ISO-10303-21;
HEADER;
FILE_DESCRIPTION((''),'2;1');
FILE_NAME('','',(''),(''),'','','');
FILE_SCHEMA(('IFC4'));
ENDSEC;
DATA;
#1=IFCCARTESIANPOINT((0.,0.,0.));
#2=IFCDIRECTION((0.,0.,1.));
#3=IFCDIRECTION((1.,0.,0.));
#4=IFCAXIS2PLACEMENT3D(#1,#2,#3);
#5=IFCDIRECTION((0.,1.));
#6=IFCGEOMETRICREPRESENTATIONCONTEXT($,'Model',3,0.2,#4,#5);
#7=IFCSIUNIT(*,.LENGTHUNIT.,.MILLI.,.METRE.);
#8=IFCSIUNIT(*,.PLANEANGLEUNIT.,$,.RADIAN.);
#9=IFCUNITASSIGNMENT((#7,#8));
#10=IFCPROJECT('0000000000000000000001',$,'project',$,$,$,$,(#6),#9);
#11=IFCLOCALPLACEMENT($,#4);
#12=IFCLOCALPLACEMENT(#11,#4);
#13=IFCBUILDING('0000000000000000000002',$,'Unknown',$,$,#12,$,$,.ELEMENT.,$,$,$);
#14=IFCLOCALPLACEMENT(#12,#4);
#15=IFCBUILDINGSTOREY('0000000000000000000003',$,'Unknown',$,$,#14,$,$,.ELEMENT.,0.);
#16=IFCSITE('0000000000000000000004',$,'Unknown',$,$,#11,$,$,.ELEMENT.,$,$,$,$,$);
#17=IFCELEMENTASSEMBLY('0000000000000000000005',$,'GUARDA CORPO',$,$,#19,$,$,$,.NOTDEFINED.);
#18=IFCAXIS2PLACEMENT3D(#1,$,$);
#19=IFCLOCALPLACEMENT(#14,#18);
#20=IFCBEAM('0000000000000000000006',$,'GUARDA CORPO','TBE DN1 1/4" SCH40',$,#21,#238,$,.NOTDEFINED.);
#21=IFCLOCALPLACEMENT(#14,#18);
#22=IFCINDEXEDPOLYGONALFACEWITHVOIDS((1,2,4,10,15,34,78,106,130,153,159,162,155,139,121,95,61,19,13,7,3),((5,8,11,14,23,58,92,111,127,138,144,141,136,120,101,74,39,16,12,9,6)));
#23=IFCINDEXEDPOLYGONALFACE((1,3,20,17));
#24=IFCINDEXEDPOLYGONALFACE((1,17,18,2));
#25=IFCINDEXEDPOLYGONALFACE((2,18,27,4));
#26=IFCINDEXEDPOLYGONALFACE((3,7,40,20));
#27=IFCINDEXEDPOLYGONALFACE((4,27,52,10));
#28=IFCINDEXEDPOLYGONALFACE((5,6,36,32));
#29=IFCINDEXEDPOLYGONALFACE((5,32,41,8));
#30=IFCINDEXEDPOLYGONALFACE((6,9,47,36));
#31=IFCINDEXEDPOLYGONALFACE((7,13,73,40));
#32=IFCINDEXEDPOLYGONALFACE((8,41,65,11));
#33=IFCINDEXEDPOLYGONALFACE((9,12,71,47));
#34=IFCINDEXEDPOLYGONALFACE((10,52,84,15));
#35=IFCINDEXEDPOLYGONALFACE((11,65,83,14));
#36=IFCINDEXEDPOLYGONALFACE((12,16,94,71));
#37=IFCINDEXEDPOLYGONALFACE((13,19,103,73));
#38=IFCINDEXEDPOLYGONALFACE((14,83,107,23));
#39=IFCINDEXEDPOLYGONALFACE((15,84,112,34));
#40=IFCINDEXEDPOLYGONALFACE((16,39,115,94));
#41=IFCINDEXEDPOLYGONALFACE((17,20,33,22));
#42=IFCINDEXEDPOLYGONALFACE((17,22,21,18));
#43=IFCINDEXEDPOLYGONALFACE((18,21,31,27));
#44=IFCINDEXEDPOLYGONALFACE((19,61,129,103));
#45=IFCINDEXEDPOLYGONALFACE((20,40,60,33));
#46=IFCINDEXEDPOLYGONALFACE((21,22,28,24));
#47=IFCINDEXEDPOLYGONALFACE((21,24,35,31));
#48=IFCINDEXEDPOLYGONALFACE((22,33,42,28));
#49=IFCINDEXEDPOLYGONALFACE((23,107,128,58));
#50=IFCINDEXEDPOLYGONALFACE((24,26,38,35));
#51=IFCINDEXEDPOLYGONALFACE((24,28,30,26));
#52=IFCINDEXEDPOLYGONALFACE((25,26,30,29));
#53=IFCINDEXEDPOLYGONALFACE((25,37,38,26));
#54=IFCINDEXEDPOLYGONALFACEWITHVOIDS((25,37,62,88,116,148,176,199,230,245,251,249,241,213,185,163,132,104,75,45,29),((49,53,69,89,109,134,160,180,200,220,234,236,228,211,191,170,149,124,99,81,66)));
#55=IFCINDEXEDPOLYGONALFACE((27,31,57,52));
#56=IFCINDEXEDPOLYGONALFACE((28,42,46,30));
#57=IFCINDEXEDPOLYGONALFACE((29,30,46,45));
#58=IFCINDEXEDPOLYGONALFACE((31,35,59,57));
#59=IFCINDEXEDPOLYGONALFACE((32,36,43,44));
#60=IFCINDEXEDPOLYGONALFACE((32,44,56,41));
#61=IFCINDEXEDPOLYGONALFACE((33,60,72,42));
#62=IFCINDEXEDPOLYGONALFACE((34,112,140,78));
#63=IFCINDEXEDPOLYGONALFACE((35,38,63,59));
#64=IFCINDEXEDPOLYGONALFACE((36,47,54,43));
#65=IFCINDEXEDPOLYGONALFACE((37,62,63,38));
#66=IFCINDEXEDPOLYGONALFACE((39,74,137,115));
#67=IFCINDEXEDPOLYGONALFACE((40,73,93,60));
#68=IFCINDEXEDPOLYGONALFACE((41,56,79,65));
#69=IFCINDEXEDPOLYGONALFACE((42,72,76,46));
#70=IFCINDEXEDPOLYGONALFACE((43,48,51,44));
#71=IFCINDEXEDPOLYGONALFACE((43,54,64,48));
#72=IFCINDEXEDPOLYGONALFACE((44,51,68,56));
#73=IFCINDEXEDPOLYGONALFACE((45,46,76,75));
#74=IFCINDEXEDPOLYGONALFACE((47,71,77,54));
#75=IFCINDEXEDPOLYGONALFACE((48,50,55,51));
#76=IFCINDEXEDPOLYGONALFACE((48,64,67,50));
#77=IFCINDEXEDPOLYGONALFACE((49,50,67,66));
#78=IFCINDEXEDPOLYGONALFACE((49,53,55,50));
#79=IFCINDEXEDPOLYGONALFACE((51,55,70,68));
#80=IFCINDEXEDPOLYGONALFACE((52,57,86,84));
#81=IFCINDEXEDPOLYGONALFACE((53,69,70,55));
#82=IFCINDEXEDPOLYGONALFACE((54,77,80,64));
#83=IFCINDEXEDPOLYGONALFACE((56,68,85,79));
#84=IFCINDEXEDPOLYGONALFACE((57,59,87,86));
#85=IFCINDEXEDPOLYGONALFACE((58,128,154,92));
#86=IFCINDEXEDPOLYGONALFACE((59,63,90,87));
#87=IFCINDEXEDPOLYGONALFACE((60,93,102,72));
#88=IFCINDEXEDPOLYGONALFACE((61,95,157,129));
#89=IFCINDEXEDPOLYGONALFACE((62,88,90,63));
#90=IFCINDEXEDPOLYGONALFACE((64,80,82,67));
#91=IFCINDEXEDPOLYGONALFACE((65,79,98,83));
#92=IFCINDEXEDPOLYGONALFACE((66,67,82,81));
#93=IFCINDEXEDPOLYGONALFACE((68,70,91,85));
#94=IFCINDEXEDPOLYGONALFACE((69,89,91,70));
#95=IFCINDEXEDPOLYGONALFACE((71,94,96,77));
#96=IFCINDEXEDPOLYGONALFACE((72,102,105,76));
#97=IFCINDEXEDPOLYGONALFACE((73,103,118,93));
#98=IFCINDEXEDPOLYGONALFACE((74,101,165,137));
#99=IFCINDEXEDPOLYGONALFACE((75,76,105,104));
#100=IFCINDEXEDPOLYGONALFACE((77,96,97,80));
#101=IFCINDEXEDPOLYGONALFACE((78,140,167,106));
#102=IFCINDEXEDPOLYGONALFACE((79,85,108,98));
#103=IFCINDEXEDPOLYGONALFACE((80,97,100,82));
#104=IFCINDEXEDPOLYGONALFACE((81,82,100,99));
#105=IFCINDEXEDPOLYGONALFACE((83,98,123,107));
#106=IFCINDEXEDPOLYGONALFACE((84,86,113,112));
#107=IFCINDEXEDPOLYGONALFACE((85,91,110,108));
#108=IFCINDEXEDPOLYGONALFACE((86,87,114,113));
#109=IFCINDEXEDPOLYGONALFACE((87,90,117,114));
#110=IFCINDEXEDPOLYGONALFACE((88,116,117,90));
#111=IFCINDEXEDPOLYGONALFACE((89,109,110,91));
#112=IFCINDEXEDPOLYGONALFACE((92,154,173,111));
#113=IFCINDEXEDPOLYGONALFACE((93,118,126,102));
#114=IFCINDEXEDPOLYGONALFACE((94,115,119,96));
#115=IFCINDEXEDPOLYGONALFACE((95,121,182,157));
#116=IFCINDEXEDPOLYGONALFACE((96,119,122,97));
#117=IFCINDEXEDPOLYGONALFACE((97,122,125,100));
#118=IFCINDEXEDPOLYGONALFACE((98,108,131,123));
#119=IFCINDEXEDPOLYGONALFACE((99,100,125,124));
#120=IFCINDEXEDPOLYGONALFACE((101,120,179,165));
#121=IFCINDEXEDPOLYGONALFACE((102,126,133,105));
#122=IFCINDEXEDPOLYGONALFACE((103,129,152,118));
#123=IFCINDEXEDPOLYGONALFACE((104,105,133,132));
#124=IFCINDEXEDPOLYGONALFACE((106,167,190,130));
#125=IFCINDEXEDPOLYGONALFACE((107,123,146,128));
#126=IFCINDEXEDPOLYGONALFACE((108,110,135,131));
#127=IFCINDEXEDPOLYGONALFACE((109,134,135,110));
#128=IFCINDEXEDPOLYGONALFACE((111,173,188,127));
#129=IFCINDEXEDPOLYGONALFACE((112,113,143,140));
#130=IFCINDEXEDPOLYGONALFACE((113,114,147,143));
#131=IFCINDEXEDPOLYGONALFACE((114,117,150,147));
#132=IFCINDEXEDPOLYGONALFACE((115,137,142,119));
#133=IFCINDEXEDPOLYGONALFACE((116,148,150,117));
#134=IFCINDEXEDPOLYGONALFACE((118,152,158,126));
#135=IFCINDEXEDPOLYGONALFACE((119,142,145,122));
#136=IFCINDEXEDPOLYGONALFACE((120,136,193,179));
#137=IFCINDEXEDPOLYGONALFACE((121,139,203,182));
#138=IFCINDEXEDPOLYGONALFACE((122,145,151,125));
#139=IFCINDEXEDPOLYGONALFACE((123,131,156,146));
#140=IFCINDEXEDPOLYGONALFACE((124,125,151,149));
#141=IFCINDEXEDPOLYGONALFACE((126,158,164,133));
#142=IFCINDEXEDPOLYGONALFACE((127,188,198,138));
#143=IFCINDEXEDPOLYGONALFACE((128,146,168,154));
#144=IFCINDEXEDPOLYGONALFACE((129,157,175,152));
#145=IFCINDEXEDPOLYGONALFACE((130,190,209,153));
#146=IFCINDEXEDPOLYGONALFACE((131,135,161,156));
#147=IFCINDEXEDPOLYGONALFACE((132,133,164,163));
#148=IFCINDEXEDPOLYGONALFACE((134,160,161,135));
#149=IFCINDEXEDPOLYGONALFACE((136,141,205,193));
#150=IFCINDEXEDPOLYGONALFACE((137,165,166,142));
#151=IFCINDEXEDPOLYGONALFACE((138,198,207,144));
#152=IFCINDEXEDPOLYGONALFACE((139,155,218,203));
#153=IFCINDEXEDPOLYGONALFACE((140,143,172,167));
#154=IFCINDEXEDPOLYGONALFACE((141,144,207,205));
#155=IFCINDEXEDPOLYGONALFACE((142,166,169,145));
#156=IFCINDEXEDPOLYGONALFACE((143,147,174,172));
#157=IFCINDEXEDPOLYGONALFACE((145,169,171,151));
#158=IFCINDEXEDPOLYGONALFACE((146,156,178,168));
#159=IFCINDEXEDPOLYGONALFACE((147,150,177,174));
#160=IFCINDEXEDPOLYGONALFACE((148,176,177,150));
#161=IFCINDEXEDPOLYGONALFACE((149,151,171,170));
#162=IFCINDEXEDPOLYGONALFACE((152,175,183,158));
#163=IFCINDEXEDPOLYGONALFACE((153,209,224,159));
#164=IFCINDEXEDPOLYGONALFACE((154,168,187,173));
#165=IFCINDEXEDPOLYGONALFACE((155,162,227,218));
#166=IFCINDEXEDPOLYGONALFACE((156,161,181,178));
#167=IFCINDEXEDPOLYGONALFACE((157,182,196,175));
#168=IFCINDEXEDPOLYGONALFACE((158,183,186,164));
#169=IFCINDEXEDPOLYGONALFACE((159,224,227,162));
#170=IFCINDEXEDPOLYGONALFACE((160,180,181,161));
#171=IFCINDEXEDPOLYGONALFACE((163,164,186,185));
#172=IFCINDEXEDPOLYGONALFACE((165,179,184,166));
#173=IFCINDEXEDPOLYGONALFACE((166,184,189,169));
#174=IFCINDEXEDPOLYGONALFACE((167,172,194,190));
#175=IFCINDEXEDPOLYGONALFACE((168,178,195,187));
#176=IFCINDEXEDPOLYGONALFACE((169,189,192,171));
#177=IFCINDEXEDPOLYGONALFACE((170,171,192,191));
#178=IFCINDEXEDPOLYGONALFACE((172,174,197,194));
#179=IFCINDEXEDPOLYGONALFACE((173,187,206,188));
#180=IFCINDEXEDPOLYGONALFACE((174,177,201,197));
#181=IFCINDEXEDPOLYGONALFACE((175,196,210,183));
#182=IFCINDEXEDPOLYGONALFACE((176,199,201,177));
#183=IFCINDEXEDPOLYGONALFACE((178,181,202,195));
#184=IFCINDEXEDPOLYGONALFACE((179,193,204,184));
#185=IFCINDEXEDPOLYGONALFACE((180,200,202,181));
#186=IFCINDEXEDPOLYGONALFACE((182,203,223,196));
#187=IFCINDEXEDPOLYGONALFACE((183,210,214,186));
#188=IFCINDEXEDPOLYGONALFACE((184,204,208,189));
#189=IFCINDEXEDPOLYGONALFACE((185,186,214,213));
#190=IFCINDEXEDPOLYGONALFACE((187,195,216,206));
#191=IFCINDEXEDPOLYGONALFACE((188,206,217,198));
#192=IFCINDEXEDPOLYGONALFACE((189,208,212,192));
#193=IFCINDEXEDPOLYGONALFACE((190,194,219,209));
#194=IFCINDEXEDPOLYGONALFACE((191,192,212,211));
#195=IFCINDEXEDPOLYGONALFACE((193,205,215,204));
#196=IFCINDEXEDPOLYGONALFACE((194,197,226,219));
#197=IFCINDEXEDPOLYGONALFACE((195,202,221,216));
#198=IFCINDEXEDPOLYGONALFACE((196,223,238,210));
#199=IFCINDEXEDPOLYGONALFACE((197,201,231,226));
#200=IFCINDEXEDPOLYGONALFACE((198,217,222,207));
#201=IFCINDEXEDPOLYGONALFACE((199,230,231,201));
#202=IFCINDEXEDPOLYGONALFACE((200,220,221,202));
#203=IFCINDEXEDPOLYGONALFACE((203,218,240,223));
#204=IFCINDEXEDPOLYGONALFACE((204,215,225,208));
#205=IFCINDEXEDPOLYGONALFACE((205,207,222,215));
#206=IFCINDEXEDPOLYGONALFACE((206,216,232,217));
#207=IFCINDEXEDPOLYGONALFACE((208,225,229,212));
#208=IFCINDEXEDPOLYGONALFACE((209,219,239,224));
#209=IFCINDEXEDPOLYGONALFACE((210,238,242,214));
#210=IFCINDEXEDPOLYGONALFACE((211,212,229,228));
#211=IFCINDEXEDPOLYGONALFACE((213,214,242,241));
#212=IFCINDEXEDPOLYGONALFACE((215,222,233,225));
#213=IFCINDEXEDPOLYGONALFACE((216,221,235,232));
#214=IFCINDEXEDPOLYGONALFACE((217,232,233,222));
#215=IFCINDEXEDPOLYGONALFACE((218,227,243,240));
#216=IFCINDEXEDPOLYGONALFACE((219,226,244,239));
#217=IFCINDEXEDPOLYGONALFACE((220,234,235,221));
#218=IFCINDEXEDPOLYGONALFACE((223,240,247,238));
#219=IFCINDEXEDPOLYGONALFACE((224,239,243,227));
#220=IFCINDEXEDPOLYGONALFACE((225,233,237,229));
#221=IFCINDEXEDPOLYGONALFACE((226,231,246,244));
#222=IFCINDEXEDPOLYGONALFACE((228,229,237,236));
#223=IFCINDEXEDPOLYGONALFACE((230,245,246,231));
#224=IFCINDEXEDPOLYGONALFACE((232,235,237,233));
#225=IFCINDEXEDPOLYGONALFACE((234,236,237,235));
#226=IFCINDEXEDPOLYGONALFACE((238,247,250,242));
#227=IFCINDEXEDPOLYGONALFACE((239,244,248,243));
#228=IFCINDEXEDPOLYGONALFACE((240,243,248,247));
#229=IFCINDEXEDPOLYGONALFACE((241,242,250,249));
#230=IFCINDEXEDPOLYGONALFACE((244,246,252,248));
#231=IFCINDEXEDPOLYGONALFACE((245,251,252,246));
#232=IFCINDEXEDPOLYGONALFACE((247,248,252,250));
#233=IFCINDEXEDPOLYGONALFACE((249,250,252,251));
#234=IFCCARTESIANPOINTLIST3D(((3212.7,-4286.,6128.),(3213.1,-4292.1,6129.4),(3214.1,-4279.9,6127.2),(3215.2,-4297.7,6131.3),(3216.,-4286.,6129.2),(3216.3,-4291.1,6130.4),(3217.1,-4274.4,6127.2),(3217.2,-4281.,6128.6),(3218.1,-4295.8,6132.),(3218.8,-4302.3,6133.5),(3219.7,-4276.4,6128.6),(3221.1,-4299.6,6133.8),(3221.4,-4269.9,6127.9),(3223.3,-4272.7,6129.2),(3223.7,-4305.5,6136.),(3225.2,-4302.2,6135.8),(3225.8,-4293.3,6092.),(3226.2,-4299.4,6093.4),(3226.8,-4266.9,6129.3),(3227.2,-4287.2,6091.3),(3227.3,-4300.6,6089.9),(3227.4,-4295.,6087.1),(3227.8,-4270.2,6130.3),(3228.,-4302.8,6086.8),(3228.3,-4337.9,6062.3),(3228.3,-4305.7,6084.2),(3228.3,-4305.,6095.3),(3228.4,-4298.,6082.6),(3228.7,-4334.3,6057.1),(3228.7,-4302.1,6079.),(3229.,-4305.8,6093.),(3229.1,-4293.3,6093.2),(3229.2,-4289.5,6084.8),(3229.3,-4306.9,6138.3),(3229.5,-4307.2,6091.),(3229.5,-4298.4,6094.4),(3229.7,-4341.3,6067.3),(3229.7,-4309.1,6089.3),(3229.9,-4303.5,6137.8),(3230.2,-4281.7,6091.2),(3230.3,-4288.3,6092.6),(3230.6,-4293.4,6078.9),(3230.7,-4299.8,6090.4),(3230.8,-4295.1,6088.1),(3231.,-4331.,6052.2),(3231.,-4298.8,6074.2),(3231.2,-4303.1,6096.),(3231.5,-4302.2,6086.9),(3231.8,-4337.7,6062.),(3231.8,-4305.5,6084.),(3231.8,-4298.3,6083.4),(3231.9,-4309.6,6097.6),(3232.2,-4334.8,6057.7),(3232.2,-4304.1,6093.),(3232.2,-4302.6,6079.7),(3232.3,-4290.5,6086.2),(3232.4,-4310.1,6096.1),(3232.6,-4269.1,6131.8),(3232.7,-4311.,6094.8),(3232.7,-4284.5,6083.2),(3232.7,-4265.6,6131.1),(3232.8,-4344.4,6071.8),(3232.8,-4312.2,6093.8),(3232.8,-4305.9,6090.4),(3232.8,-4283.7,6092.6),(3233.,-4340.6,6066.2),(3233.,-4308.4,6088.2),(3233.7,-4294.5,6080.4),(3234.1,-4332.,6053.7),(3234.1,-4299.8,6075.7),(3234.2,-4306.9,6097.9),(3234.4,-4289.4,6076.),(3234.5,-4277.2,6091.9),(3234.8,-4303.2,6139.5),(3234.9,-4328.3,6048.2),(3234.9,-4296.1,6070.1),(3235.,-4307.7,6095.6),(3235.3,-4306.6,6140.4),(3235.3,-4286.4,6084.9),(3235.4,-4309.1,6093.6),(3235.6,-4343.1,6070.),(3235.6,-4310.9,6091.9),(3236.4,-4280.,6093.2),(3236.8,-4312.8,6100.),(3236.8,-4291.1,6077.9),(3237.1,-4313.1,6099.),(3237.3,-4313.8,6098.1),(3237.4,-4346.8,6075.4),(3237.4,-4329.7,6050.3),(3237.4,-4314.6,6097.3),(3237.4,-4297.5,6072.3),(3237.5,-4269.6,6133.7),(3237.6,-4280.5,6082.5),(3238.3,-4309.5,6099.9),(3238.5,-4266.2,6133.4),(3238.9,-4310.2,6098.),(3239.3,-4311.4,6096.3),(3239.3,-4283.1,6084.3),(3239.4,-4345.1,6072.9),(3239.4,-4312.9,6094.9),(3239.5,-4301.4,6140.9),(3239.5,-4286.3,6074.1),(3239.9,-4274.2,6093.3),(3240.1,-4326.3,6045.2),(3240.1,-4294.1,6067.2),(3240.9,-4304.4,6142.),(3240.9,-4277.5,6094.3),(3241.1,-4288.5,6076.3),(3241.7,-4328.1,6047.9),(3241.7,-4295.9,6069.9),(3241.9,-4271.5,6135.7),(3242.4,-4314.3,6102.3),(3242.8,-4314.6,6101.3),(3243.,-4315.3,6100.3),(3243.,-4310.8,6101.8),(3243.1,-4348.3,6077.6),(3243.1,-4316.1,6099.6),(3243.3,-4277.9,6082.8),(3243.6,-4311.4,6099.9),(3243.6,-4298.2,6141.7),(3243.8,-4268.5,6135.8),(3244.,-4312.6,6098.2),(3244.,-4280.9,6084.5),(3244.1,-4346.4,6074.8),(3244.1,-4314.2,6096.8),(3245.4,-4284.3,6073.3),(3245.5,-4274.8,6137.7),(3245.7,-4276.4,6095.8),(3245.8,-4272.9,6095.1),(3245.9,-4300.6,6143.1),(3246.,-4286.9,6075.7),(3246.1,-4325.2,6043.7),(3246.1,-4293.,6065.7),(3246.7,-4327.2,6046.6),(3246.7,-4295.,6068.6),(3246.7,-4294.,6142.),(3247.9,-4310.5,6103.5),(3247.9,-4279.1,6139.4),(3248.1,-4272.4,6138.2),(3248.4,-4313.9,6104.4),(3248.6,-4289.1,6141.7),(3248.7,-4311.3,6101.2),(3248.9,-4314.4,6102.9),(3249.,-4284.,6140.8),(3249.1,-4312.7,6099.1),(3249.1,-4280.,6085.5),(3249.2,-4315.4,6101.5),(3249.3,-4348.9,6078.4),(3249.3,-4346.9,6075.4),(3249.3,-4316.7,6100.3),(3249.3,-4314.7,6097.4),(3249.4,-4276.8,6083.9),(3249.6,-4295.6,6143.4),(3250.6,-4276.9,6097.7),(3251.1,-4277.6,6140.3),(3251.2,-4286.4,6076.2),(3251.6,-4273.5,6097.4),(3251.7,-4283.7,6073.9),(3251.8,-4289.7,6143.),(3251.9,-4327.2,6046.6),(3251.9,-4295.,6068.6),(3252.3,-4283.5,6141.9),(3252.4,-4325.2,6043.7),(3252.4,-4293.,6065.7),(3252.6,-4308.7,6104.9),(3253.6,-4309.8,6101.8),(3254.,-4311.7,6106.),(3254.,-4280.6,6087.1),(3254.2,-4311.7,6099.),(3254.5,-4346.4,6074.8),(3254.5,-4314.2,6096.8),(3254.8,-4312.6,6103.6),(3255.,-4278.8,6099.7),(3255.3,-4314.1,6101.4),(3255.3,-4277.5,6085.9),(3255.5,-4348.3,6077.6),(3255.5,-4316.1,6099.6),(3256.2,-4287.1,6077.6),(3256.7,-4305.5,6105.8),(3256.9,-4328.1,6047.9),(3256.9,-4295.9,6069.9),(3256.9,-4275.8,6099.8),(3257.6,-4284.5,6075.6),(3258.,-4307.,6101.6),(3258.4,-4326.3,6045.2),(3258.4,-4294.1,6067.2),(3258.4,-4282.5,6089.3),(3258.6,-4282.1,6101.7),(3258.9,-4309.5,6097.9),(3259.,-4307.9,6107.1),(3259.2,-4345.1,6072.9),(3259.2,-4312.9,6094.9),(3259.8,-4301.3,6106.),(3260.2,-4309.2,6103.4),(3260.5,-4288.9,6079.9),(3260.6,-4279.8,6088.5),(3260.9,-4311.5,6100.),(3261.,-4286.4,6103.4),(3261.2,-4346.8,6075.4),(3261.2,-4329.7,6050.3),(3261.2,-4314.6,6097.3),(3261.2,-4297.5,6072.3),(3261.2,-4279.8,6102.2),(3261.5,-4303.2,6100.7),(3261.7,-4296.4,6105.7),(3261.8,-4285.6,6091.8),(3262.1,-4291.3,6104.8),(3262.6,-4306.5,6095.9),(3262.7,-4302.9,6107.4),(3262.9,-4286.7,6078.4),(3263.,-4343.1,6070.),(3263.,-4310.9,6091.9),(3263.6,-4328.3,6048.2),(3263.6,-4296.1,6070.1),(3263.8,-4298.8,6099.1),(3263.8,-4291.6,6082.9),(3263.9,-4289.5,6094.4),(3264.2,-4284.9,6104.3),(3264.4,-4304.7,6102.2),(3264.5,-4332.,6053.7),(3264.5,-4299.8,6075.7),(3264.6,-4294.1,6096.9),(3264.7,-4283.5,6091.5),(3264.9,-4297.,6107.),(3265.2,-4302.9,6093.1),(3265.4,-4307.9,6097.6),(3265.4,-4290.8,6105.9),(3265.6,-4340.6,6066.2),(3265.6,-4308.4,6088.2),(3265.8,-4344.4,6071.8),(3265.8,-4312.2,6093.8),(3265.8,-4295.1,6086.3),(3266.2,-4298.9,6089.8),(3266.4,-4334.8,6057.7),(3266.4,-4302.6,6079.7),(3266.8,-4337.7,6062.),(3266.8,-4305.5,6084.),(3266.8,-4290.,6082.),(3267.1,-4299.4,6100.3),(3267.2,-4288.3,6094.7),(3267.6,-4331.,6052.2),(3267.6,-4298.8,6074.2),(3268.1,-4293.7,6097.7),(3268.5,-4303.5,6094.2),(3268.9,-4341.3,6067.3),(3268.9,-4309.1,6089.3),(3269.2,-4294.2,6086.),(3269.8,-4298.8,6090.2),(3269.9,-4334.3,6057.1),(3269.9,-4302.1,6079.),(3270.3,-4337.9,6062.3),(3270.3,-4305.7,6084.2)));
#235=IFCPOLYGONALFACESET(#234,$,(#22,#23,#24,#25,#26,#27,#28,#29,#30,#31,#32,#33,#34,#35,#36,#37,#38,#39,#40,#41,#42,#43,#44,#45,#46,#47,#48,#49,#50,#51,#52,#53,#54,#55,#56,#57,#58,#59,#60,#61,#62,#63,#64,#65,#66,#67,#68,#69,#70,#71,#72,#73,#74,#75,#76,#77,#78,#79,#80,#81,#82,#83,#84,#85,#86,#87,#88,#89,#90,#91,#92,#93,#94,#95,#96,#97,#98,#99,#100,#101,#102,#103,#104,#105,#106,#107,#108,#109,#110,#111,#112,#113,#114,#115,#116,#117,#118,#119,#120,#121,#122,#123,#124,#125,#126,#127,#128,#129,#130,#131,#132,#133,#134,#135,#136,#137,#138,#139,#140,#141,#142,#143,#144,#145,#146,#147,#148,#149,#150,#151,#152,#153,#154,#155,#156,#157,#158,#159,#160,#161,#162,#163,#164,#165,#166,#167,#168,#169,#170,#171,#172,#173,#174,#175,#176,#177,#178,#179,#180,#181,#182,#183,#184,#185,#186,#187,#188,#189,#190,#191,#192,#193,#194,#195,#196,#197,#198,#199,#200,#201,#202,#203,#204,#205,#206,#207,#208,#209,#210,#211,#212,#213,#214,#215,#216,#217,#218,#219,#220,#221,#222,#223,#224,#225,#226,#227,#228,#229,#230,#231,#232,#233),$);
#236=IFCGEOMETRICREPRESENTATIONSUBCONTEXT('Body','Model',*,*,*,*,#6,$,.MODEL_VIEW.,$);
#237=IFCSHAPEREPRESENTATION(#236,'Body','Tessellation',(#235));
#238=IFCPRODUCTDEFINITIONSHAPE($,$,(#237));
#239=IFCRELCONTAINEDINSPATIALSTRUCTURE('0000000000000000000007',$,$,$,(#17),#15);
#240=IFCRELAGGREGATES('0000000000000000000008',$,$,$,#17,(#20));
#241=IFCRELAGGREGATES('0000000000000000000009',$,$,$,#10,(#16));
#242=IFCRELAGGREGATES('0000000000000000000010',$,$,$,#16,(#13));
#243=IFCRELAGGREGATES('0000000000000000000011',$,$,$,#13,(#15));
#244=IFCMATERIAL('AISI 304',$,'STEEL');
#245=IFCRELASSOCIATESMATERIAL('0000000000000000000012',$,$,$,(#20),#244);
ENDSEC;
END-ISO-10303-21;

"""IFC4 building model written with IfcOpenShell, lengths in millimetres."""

from ifc_helpers import new_model, entity, si_unit, direction, frame, origin_with_axes, place, context, subcontext, project, spatial, material, element, aggregate, save


model = new_model("IFC4")

# Units and contexts
model_context = context("Model", 3, precision=0.2, world=origin_with_axes(), true_north=direction((0.0, 1.0)))
body_context = subcontext(model_context, "Body", "Model", "MODEL_VIEW")
ifc_project = project(units=[si_unit("LENGTHUNIT", "METRE", prefix="MILLI"), si_unit("PLANEANGLEUNIT", "RADIAN")], contexts=[model_context])

# Site, building, storey
site_placement = place(None, origin_with_axes())
site = spatial("IfcSite", under=ifc_project, at=site_placement, Name="Unknown", CompositionType="ELEMENT")
building_placement = place(site_placement, origin_with_axes())
building = spatial("IfcBuilding", under=site, at=building_placement, Name="Unknown", CompositionType="ELEMENT")
storey_placement = place(building_placement, origin_with_axes())
storey = spatial("IfcBuildingStorey", under=building, at=storey_placement, Name="Unknown", CompositionType="ELEMENT", Elevation=0.0)

# Element assembly, beam
assembly_1_placement = place(storey_placement, frame((2908.2, -5645.6, 3955.0), z_axis=(0.000512, -1.0, -0.000003), x_axis=(0.000003, -0.000003, 1.0)))
assembly_1 = element("IfcElementAssembly", 1, at=assembly_1_placement, inside=storey, Name="GUARDA CORPO", PredefinedType="NOTDEFINED")
ifc_material_1 = material(Name="AISI 304", Category="STEEL")
beam_1_placement = place(assembly_1_placement, frame((2105.9, -341.8, -1308.4), z_axis=(0.826215, 0.000295, 0.563355), x_axis=(0.563355, -0.000419, -0.826215)))
beam_1 = element("IfcBeam", 2, at=beam_1_placement, material=ifc_material_1, Name="GUARDA CORPO", Description="TBE DN1 1/4\" SCH40", PredefinedType="NOTDEFINED", context=body_context, shape_type="SolidModel", body=[
    entity("IfcSweptDiskSolid", entity("IfcIndexedPolyCurve", entity("IfcCartesianPointList3D", [[0.0, 0.0, 0.0], [39.0, 0.0, 0.0], [49.1, 1.0, 1.9], [57.4, 3.7, 7.2], [83.7, 16.8, 32.9]]), [entity("IfcLineIndex", [1, 2]), entity("IfcArcIndex", [2, 3, 4]), entity("IfcLineIndex", [4, 5])]), 21.1, 17.5),
])

aggregate(assembly_1, [beam_1])

save(model, "model.ifc")
